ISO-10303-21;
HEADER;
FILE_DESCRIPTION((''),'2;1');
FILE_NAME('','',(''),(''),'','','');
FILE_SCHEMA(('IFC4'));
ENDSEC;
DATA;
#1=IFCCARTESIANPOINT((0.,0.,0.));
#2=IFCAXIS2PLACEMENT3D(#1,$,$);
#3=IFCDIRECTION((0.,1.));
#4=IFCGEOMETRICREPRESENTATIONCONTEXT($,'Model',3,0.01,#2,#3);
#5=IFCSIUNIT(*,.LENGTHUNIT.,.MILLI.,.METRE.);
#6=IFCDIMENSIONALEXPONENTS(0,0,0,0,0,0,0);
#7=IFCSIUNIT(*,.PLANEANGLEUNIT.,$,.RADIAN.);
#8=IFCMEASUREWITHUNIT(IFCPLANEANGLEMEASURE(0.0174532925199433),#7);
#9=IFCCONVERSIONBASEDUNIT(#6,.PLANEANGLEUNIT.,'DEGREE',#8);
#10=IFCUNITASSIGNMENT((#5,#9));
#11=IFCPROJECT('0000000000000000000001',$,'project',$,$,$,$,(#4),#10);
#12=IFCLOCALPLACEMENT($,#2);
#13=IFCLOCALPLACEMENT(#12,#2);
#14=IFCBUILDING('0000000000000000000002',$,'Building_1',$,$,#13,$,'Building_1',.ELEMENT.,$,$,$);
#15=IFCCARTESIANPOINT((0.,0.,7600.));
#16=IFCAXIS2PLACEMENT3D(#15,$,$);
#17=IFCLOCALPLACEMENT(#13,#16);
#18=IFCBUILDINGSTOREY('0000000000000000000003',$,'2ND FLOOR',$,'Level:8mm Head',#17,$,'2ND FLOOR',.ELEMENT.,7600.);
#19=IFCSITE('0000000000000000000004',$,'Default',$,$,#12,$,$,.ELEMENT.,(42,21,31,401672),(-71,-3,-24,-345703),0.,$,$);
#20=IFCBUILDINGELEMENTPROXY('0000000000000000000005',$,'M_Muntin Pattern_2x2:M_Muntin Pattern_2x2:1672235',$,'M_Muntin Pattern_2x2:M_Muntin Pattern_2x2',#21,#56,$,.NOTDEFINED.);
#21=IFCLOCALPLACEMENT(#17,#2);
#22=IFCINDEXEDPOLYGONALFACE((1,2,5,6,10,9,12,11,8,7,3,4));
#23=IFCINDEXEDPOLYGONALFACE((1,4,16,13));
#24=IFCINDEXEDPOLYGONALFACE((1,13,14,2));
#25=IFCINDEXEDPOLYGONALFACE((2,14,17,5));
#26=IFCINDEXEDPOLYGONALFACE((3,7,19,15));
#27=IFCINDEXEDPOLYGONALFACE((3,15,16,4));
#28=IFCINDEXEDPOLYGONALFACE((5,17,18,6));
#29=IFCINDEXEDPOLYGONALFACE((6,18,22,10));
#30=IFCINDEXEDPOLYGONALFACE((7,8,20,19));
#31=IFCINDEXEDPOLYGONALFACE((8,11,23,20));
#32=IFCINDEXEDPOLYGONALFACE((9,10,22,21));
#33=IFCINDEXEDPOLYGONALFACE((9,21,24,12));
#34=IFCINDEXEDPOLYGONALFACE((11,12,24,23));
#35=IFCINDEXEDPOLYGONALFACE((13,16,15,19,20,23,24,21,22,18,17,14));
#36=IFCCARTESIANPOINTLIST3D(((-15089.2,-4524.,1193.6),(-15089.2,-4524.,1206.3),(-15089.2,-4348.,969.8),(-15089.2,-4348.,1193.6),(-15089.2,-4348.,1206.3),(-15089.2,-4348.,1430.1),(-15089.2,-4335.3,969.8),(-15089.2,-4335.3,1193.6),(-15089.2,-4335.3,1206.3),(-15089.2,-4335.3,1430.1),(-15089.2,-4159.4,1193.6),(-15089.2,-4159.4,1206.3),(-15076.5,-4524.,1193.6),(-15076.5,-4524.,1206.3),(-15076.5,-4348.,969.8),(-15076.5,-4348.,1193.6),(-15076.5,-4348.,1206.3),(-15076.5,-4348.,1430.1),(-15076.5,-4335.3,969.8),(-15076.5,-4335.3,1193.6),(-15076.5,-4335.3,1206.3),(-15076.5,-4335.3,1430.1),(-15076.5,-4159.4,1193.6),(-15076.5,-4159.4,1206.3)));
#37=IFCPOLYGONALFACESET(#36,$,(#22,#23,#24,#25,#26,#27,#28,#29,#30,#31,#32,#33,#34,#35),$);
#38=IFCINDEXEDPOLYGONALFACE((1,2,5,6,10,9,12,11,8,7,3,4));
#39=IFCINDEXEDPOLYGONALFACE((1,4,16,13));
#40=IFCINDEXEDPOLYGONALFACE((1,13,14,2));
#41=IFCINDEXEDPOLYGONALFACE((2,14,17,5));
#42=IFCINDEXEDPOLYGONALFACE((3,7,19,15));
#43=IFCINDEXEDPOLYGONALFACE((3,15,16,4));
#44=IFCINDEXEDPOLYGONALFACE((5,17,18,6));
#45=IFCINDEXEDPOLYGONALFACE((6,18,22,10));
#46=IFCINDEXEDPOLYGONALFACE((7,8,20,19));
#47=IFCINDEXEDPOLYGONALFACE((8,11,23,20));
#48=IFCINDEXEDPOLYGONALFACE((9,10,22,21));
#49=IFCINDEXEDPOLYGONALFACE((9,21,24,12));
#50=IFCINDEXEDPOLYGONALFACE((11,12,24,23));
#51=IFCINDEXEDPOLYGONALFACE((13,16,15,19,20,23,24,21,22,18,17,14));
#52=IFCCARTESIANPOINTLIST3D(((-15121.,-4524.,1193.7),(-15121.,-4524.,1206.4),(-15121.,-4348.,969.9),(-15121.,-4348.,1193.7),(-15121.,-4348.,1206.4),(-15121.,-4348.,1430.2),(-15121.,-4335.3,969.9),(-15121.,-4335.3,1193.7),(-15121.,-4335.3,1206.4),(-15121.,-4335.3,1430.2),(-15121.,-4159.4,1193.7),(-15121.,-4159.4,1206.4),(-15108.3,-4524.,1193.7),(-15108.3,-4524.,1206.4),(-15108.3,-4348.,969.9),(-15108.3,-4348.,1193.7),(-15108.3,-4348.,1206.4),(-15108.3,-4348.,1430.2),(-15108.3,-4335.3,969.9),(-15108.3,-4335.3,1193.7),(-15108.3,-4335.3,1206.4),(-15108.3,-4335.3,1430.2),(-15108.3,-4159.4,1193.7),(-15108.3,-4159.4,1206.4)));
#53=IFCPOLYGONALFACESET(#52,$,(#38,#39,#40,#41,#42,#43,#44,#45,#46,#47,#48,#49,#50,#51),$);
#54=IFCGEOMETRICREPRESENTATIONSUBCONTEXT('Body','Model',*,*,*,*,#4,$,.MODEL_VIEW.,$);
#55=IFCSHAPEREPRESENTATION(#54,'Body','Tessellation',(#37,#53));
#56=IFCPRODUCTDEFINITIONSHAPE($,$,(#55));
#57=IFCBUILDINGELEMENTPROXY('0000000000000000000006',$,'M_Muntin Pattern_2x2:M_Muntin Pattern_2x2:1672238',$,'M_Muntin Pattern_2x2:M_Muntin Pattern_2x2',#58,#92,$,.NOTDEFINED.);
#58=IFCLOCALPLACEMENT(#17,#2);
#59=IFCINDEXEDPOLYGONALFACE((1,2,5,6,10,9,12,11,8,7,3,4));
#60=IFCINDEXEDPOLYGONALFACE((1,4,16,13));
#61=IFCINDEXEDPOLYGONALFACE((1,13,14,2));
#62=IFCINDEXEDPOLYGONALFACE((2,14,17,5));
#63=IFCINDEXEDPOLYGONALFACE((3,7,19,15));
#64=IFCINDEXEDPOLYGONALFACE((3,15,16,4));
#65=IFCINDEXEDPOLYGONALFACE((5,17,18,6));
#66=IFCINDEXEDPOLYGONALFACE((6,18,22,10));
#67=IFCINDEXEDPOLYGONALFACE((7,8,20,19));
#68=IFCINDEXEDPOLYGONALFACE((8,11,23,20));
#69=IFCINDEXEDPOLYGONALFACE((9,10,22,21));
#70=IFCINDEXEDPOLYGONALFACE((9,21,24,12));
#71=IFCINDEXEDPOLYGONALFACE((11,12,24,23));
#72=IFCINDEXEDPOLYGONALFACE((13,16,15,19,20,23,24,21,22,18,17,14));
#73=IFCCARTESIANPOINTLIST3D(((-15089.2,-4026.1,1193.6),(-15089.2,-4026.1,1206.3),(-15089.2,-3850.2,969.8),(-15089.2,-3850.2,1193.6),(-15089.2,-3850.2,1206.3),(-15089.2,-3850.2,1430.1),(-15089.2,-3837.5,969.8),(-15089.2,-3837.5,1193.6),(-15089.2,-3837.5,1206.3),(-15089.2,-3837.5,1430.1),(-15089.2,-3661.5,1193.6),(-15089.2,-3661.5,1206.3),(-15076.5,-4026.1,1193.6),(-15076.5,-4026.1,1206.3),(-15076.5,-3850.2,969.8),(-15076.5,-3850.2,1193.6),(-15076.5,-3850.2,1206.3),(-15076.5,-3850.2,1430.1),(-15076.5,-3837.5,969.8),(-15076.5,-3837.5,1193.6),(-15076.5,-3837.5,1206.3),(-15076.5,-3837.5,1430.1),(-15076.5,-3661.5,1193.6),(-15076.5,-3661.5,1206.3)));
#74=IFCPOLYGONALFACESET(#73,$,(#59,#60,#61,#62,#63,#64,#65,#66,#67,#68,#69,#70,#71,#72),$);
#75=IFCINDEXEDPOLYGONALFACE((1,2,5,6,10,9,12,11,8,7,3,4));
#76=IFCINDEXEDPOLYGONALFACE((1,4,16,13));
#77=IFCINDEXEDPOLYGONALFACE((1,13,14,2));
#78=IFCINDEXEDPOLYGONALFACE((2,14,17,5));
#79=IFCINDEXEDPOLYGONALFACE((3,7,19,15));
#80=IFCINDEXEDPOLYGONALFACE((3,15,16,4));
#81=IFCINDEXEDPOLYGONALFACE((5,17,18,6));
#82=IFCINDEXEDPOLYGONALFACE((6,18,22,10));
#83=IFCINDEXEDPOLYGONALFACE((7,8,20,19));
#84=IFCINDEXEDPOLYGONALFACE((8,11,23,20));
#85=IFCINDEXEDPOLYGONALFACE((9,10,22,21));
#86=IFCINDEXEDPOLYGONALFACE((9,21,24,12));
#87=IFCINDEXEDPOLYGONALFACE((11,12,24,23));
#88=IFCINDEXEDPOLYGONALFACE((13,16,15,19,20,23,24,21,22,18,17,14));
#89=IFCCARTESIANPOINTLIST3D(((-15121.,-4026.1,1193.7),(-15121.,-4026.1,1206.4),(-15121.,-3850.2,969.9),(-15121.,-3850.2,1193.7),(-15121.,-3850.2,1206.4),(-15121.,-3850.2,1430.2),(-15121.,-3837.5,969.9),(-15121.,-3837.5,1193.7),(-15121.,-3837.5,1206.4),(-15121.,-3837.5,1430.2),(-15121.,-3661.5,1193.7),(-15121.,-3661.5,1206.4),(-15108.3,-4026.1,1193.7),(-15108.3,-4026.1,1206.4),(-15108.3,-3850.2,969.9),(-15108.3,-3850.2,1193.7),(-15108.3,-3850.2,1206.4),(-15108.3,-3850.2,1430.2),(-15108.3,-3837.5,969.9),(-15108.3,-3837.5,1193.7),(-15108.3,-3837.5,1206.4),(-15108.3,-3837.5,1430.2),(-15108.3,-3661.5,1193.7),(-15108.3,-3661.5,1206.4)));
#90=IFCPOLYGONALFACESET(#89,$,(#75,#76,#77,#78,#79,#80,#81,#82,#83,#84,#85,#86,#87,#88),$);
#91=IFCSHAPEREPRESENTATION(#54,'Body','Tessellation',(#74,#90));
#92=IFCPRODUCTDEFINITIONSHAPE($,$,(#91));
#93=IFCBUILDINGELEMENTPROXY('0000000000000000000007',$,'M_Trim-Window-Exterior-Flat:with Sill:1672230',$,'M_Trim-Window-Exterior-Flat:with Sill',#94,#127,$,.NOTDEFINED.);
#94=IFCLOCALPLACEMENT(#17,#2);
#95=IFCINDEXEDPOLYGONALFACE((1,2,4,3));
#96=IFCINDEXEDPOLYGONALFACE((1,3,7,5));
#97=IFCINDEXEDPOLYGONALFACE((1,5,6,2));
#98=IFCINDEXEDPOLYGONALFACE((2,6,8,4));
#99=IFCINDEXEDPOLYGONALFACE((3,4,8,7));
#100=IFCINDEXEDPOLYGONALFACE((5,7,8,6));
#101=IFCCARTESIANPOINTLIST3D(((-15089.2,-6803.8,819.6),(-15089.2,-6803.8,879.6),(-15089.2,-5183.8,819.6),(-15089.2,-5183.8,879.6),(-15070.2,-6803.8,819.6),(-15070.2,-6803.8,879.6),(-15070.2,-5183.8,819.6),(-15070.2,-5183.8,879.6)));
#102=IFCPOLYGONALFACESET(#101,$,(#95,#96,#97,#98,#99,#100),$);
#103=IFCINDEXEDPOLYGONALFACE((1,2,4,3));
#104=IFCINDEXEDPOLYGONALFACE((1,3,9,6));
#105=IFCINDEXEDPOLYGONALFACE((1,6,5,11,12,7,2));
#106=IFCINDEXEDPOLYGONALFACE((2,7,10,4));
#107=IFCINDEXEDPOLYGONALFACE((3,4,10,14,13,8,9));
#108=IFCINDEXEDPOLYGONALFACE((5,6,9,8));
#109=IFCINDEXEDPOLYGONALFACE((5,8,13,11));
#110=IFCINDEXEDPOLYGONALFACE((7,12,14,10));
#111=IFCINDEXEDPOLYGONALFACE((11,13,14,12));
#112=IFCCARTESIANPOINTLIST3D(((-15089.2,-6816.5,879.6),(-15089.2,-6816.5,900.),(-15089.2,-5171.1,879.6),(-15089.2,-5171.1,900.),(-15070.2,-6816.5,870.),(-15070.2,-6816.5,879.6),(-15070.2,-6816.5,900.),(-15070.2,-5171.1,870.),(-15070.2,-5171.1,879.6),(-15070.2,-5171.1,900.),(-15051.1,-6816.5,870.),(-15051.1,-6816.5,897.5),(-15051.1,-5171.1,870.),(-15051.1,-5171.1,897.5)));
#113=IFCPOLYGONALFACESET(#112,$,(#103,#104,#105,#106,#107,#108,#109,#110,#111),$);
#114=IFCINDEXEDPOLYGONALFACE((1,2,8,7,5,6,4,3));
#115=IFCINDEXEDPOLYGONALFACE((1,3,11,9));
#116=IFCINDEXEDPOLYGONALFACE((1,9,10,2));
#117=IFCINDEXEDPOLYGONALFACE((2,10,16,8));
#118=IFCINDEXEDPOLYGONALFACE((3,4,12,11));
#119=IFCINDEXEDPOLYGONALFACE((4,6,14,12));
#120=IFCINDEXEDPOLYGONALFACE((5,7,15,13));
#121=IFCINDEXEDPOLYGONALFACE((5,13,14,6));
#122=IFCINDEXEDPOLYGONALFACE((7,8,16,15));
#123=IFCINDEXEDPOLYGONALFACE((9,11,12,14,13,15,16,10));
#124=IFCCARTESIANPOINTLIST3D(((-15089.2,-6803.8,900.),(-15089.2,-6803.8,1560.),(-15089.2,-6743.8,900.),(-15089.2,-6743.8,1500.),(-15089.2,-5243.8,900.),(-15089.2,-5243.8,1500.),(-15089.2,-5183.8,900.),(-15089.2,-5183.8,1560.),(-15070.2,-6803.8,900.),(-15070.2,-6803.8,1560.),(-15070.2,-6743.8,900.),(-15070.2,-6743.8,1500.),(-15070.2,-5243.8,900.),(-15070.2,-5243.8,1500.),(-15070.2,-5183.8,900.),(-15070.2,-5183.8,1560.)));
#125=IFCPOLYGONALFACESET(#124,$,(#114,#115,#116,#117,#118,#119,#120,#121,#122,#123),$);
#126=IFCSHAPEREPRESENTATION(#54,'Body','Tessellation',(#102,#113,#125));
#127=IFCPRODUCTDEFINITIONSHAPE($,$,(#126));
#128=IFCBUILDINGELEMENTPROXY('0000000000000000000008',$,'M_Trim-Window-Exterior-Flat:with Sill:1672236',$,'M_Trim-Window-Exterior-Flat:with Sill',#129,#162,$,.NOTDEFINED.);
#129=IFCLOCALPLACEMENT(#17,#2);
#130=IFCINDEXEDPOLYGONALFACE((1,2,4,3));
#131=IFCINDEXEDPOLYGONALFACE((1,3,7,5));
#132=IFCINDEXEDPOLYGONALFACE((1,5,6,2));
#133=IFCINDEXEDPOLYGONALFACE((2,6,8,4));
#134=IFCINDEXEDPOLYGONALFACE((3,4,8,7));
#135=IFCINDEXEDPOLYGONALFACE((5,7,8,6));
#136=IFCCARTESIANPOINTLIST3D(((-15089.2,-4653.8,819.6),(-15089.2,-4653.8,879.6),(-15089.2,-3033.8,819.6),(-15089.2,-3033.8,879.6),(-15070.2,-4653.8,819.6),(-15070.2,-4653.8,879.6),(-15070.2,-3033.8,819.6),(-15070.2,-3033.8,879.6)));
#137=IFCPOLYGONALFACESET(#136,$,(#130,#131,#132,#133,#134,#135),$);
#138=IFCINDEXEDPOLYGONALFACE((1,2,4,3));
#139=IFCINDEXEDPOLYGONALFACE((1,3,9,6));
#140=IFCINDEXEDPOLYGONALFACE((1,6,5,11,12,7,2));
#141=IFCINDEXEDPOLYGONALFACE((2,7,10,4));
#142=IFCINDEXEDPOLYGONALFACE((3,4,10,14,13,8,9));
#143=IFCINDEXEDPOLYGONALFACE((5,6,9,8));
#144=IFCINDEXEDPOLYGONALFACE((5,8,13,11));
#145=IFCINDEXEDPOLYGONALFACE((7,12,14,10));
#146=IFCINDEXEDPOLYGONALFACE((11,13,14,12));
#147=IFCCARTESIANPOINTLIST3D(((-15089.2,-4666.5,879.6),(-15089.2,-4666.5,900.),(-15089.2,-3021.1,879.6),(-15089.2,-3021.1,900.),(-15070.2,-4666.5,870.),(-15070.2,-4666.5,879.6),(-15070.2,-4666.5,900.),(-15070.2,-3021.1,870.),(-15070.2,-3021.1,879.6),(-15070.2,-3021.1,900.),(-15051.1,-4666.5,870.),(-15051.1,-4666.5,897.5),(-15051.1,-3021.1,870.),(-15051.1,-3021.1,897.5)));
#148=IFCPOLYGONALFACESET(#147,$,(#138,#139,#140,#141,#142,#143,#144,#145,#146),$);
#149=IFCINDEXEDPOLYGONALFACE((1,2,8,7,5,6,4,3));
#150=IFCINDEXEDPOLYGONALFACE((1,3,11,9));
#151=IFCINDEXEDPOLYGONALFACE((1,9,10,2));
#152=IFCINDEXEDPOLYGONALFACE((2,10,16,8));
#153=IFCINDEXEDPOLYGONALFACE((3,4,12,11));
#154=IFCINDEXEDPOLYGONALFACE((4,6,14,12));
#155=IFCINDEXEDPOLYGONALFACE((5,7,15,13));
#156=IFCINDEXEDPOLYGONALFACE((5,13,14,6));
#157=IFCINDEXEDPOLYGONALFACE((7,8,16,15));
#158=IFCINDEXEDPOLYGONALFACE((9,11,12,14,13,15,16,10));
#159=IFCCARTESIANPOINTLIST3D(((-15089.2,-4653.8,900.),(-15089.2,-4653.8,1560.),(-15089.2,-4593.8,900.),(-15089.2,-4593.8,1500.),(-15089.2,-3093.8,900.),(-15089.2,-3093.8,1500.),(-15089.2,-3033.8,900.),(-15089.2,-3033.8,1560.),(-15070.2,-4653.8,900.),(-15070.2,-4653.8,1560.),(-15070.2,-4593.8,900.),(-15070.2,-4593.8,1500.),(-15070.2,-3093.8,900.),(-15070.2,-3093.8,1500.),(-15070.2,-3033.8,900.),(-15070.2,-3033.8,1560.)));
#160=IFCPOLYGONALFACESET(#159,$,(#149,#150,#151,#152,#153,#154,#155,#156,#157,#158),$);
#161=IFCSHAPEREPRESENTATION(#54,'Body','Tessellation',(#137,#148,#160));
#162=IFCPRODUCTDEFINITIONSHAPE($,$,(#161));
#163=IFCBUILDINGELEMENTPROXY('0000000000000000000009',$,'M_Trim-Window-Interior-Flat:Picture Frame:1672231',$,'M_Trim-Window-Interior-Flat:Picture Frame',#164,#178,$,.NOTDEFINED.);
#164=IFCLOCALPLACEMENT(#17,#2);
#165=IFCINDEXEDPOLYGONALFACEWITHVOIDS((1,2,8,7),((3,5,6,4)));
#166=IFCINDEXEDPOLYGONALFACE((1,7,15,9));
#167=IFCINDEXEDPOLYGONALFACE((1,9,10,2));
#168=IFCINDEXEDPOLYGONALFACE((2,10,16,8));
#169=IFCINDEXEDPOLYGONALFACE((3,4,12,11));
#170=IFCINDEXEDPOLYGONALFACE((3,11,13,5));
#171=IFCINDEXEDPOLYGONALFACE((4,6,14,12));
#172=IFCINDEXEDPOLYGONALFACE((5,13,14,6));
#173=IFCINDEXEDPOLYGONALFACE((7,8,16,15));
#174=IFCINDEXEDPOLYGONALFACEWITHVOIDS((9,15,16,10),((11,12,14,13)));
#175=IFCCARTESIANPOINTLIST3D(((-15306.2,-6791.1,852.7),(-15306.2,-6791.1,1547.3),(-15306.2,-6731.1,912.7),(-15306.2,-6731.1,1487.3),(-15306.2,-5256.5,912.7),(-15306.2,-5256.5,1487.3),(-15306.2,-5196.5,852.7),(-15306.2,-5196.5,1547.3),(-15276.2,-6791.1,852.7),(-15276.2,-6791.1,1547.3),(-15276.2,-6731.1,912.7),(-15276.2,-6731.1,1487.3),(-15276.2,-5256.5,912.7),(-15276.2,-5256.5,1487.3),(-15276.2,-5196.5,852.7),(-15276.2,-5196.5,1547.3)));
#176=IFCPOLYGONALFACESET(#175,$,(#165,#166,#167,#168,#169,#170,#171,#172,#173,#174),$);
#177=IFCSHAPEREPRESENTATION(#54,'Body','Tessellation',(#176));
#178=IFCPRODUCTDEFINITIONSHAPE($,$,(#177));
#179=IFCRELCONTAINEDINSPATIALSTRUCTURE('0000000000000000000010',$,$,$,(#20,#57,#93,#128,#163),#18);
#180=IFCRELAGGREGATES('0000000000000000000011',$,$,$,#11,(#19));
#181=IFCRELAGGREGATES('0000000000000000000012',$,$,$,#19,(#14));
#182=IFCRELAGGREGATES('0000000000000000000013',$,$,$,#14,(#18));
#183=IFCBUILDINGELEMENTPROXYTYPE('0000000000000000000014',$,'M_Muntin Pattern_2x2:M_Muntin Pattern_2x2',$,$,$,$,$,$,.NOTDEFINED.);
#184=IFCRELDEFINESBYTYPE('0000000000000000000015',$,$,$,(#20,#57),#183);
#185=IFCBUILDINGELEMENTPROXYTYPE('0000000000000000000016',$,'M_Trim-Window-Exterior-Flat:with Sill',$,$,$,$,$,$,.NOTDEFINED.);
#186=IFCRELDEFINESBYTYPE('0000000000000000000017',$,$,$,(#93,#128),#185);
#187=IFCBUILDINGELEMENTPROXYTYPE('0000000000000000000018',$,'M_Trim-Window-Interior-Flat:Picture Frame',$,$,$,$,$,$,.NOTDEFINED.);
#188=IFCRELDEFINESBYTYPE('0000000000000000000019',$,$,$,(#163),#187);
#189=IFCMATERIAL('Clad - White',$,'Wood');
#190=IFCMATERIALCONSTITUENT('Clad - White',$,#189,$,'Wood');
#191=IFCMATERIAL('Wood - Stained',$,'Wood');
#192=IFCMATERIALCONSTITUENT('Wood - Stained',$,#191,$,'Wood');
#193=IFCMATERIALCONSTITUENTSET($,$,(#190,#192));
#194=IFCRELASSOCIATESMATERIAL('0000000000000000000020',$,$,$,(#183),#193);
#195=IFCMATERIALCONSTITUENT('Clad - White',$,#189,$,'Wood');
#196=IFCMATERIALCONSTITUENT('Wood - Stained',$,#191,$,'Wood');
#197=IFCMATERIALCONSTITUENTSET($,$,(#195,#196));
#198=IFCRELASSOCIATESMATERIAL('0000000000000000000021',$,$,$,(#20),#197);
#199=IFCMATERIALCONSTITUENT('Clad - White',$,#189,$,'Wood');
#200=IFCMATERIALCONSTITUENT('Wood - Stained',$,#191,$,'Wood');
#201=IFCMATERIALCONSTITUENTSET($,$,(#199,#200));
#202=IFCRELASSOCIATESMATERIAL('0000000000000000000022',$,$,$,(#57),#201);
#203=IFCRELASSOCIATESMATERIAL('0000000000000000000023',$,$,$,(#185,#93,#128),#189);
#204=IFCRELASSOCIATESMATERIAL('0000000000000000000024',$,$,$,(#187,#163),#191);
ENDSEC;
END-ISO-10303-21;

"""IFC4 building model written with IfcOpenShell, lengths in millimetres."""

from ifc_helpers import new_model, entity, si_unit, converted_unit, direction, frame, origin, place, context, subcontext, project, spatial, indexed_curve, outline, extrude, source, transform, mapped, material, constituent, constituent_set, type_object, type_shapes, element, save


model = new_model("IFC4")

# Units and contexts
model_context = context("Model", 3, precision=0.01, world=origin(), true_north=direction((0.0, 1.0)))
body_context = subcontext(model_context, "Body", "Model", "MODEL_VIEW")
ifc_project = project(units=[si_unit("LENGTHUNIT", "METRE", prefix="MILLI"), converted_unit("PLANEANGLEUNIT", "DEGREE", entity("IfcPlaneAngleMeasure", 0.0174532925199433), si_unit("PLANEANGLEUNIT", "RADIAN"), dimensions=[0, 0, 0, 0, 0, 0, 0])], contexts=[model_context])

# Site, building, storey
site_placement = place(None, origin())
site = spatial("IfcSite", under=ifc_project, at=site_placement, Name="Default", CompositionType="ELEMENT", RefLatitude=(42, 21, 31, 401672), RefLongitude=(-71, -3, -24, -345703), RefElevation=0.0)
building_placement = place(site_placement, origin())
building = spatial("IfcBuilding", under=site, at=building_placement, Name="Building_1", LongName="Building_1", CompositionType="ELEMENT")
storey_placement = place(building_placement, frame((0.0, 0.0, 7600.0)))
storey = spatial("IfcBuildingStorey", under=building, at=storey_placement, Name="2ND FLOOR", ObjectType="Level:8mm Head", LongName="2ND FLOOR", CompositionType="ELEMENT", Elevation=7600.0)

# Shared definitions
ifc_material_1 = material(Name="Wood - Stained", Category="Wood")

# Building element proxies
ifc_material_2 = material(Name="Clad - White", Category="Wood")
ifc_constituent_1 = constituent(ifc_material_2, Name="Clad - White", Category="Wood")
ifc_constituent_2 = constituent(ifc_material_1, Name="Wood - Stained", Category="Wood")
ifc_constituent_set_1 = constituent_set(constituents=[ifc_constituent_1, ifc_constituent_2])
building_element_proxy_type_1 = type_object("IfcBuildingElementProxyType", Name="M_Muntin Pattern_2x2:M_Muntin Pattern_2x2", PredefinedType="NOTDEFINED", material=ifc_constituent_set_1)
shared_shape_1 = source(origin(), body_context, "Body", "SweptSolid", [
    extrude(outline(indexed_curve([(6.4, -6.4), (230.1, -6.4), (230.1, 6.3), (6.4, 6.3), (6.4, 182.3), (-6.3, 182.3), (-6.3, 6.3), (-230.2, 6.3), (-230.2, -6.4), (-6.3, -6.4), (-6.3, -182.3), (6.4, -182.3), (6.4, -6.4)], self_intersect=False)), frame((0.0, -22.2, 230.1), z_axis=(0.0, 1.0, 0.0), x_axis=(0.0, 0.0, 1.0)), (0.0, 0.0, 1.0), 12.7),
    extrude(outline(indexed_curve([(6.4, -6.4), (230.2, -6.4), (230.2, 6.3), (6.4, 6.3), (6.4, 182.3), (-6.3, 182.3), (-6.3, 6.3), (-230.2, 6.3), (-230.2, -6.4), (-6.3, -6.4), (-6.3, -182.3), (6.4, -182.3), (6.4, -6.4)], self_intersect=False)), frame((0.0, 9.5, 230.2), z_axis=(0.0, 1.0, 0.0), x_axis=(0.0, 0.0, 1.0)), (0.0, 0.0, 1.0), 12.7),
])
type_shapes(building_element_proxy_type_1, [shared_shape_1])
ifc_constituent_3 = constituent(ifc_material_2, Name="Clad - White", Category="Wood")
ifc_constituent_4 = constituent(ifc_material_1, Name="Wood - Stained", Category="Wood")
ifc_constituent_set_2 = constituent_set(constituents=[ifc_constituent_3, ifc_constituent_4])
proxy_1_placement = place(storey_placement, frame((-15098.7, -4341.7, 969.9), z_axis=(0.0, 0.0, 1.0), x_axis=(0.0, 1.0, 0.0)))
element("IfcBuildingElementProxy", 1, at=proxy_1_placement, inside=storey, type_object=building_element_proxy_type_1, material=ifc_constituent_set_2, Name="M_Muntin Pattern_2x2:M_Muntin Pattern_2x2:1672235", ObjectType="M_Muntin Pattern_2x2:M_Muntin Pattern_2x2", PredefinedType="NOTDEFINED", context=body_context, shape_type="MappedRepresentation", body=[
    mapped(shared_shape_1, transform((0.0, 0.0, 0.0), scale=1.0)),
])
ifc_constituent_5 = constituent(ifc_material_2, Name="Clad - White", Category="Wood")
ifc_constituent_6 = constituent(ifc_material_1, Name="Wood - Stained", Category="Wood")
ifc_constituent_set_3 = constituent_set(constituents=[ifc_constituent_5, ifc_constituent_6])
proxy_2_placement = place(storey_placement, frame((-15098.7, -3843.8, 969.9), z_axis=(0.0, 0.0, 1.0), x_axis=(0.0, 1.0, 0.0)))
element("IfcBuildingElementProxy", 2, at=proxy_2_placement, inside=storey, type_object=building_element_proxy_type_1, material=ifc_constituent_set_3, Name="M_Muntin Pattern_2x2:M_Muntin Pattern_2x2:1672238", ObjectType="M_Muntin Pattern_2x2:M_Muntin Pattern_2x2", PredefinedType="NOTDEFINED", context=body_context, shape_type="MappedRepresentation", body=[
    mapped(shared_shape_1, transform((0.0, 0.0, 0.0), scale=1.0)),
])
building_element_proxy_type_2 = type_object("IfcBuildingElementProxyType", Name="M_Trim-Window-Exterior-Flat:with Sill", PredefinedType="NOTDEFINED", material=ifc_material_2)
shared_shape_2 = source(origin(), body_context, "Body", "SweptSolid", [
    extrude(outline(indexed_curve([(-810.0, -30.0), (810.0, -30.0), (810.0, 30.0), (-810.0, 30.0), (-810.0, -30.0)], self_intersect=False)), frame((0.0, -650.4, 0.0), z_axis=(0.0, 0.0, 1.0), x_axis=(-1.0, 0.0, 0.0)), (0.0, 0.0, 1.0), 19.1),
    extrude(outline(indexed_curve([(-19.0, -15.2), (0.0, -15.2), (0.0, -5.7), (19.0, -5.7), (19.0, 14.8), (0.0, 14.8), (-19.0, 12.3), (-19.0, -15.2)], self_intersect=False)), frame((-822.7, -614.8, 19.0), z_axis=(1.0, 0.0, 0.0), x_axis=(0.0, 0.0, -1.0)), (0.0, 0.0, 1.0), 1645.4),
    extrude(outline(indexed_curve([(-345.0, -810.0), (315.0, -810.0), (315.0, -750.0), (-285.0, -750.0), (-285.0, 750.0), (315.0, 750.0), (315.0, 810.0), (-345.0, 810.0), (-345.0, -810.0)], self_intersect=False)), frame((0.0, -285.0, 0.0), z_axis=(0.0, 0.0, 1.0), x_axis=(0.0, -1.0, 0.0)), (0.0, 0.0, 1.0), 19.1),
])
type_shapes(building_element_proxy_type_2, [shared_shape_2])
for number, where, z_axis, x_axis, name in (
    (3, (-15089.2, -5993.8, 1500.0), (1.0, 0.0, 0.0), (0.0, 1.0, 0.0), "M_Trim-Window-Exterior-Flat:with Sill:1672230"),
    (4, (-15089.2, -3843.8, 1500.0), (1.0, 0.0, 0.0), (0.0, 1.0, 0.0), "M_Trim-Window-Exterior-Flat:with Sill:1672236"),
):
    element("IfcBuildingElementProxy", number, at=place(storey_placement, frame(where, z_axis=z_axis, x_axis=x_axis)), inside=storey, type_object=building_element_proxy_type_2, material=ifc_material_2, Name=name, ObjectType="M_Trim-Window-Exterior-Flat:with Sill", PredefinedType="NOTDEFINED", context=body_context, shape_type="MappedRepresentation", body=[
        mapped(shared_shape_2, transform((0.0, 0.0, 0.0), scale=1.0)),
    ])
building_element_proxy_type_3 = type_object("IfcBuildingElementProxyType", Name="M_Trim-Window-Interior-Flat:Picture Frame", PredefinedType="NOTDEFINED", material=ifc_material_1)
shared_shape_3 = source(origin(), body_context, "Body", "SweptSolid", [
    extrude(outline(indexed_curve([(-797.3, -347.3), (797.3, -347.3), (797.3, 347.3), (-797.3, 347.3), (-797.3, -347.3)], self_intersect=False), holes=[indexed_curve([(-737.3, -287.3), (-737.3, 287.3), (737.3, 287.3), (737.3, -287.3), (-737.3, -287.3)], self_intersect=False)]), frame((0.0, -300.0, 0.0), z_axis=(0.0, 0.0, 1.0), x_axis=(-1.0, 0.0, 0.0)), (0.0, 0.0, 1.0), 30.0),
])
type_shapes(building_element_proxy_type_3, [shared_shape_3])
for number, where, z_axis, x_axis, name in (
    (5, (-15276.2, -5993.8, 1500.0), (-1.0, 0.0, 0.0), (0.0, -1.0, 0.0), "M_Trim-Window-Interior-Flat:Picture Frame:1672231"),
):
    element("IfcBuildingElementProxy", number, at=place(storey_placement, frame(where, z_axis=z_axis, x_axis=x_axis)), inside=storey, type_object=building_element_proxy_type_3, material=ifc_material_1, Name=name, ObjectType="M_Trim-Window-Interior-Flat:Picture Frame", PredefinedType="NOTDEFINED", context=body_context, shape_type="MappedRepresentation", body=[
        mapped(shared_shape_3, transform((0.0, 0.0, 0.0), scale=1.0)),
    ])

save(model, "model.ifc")
